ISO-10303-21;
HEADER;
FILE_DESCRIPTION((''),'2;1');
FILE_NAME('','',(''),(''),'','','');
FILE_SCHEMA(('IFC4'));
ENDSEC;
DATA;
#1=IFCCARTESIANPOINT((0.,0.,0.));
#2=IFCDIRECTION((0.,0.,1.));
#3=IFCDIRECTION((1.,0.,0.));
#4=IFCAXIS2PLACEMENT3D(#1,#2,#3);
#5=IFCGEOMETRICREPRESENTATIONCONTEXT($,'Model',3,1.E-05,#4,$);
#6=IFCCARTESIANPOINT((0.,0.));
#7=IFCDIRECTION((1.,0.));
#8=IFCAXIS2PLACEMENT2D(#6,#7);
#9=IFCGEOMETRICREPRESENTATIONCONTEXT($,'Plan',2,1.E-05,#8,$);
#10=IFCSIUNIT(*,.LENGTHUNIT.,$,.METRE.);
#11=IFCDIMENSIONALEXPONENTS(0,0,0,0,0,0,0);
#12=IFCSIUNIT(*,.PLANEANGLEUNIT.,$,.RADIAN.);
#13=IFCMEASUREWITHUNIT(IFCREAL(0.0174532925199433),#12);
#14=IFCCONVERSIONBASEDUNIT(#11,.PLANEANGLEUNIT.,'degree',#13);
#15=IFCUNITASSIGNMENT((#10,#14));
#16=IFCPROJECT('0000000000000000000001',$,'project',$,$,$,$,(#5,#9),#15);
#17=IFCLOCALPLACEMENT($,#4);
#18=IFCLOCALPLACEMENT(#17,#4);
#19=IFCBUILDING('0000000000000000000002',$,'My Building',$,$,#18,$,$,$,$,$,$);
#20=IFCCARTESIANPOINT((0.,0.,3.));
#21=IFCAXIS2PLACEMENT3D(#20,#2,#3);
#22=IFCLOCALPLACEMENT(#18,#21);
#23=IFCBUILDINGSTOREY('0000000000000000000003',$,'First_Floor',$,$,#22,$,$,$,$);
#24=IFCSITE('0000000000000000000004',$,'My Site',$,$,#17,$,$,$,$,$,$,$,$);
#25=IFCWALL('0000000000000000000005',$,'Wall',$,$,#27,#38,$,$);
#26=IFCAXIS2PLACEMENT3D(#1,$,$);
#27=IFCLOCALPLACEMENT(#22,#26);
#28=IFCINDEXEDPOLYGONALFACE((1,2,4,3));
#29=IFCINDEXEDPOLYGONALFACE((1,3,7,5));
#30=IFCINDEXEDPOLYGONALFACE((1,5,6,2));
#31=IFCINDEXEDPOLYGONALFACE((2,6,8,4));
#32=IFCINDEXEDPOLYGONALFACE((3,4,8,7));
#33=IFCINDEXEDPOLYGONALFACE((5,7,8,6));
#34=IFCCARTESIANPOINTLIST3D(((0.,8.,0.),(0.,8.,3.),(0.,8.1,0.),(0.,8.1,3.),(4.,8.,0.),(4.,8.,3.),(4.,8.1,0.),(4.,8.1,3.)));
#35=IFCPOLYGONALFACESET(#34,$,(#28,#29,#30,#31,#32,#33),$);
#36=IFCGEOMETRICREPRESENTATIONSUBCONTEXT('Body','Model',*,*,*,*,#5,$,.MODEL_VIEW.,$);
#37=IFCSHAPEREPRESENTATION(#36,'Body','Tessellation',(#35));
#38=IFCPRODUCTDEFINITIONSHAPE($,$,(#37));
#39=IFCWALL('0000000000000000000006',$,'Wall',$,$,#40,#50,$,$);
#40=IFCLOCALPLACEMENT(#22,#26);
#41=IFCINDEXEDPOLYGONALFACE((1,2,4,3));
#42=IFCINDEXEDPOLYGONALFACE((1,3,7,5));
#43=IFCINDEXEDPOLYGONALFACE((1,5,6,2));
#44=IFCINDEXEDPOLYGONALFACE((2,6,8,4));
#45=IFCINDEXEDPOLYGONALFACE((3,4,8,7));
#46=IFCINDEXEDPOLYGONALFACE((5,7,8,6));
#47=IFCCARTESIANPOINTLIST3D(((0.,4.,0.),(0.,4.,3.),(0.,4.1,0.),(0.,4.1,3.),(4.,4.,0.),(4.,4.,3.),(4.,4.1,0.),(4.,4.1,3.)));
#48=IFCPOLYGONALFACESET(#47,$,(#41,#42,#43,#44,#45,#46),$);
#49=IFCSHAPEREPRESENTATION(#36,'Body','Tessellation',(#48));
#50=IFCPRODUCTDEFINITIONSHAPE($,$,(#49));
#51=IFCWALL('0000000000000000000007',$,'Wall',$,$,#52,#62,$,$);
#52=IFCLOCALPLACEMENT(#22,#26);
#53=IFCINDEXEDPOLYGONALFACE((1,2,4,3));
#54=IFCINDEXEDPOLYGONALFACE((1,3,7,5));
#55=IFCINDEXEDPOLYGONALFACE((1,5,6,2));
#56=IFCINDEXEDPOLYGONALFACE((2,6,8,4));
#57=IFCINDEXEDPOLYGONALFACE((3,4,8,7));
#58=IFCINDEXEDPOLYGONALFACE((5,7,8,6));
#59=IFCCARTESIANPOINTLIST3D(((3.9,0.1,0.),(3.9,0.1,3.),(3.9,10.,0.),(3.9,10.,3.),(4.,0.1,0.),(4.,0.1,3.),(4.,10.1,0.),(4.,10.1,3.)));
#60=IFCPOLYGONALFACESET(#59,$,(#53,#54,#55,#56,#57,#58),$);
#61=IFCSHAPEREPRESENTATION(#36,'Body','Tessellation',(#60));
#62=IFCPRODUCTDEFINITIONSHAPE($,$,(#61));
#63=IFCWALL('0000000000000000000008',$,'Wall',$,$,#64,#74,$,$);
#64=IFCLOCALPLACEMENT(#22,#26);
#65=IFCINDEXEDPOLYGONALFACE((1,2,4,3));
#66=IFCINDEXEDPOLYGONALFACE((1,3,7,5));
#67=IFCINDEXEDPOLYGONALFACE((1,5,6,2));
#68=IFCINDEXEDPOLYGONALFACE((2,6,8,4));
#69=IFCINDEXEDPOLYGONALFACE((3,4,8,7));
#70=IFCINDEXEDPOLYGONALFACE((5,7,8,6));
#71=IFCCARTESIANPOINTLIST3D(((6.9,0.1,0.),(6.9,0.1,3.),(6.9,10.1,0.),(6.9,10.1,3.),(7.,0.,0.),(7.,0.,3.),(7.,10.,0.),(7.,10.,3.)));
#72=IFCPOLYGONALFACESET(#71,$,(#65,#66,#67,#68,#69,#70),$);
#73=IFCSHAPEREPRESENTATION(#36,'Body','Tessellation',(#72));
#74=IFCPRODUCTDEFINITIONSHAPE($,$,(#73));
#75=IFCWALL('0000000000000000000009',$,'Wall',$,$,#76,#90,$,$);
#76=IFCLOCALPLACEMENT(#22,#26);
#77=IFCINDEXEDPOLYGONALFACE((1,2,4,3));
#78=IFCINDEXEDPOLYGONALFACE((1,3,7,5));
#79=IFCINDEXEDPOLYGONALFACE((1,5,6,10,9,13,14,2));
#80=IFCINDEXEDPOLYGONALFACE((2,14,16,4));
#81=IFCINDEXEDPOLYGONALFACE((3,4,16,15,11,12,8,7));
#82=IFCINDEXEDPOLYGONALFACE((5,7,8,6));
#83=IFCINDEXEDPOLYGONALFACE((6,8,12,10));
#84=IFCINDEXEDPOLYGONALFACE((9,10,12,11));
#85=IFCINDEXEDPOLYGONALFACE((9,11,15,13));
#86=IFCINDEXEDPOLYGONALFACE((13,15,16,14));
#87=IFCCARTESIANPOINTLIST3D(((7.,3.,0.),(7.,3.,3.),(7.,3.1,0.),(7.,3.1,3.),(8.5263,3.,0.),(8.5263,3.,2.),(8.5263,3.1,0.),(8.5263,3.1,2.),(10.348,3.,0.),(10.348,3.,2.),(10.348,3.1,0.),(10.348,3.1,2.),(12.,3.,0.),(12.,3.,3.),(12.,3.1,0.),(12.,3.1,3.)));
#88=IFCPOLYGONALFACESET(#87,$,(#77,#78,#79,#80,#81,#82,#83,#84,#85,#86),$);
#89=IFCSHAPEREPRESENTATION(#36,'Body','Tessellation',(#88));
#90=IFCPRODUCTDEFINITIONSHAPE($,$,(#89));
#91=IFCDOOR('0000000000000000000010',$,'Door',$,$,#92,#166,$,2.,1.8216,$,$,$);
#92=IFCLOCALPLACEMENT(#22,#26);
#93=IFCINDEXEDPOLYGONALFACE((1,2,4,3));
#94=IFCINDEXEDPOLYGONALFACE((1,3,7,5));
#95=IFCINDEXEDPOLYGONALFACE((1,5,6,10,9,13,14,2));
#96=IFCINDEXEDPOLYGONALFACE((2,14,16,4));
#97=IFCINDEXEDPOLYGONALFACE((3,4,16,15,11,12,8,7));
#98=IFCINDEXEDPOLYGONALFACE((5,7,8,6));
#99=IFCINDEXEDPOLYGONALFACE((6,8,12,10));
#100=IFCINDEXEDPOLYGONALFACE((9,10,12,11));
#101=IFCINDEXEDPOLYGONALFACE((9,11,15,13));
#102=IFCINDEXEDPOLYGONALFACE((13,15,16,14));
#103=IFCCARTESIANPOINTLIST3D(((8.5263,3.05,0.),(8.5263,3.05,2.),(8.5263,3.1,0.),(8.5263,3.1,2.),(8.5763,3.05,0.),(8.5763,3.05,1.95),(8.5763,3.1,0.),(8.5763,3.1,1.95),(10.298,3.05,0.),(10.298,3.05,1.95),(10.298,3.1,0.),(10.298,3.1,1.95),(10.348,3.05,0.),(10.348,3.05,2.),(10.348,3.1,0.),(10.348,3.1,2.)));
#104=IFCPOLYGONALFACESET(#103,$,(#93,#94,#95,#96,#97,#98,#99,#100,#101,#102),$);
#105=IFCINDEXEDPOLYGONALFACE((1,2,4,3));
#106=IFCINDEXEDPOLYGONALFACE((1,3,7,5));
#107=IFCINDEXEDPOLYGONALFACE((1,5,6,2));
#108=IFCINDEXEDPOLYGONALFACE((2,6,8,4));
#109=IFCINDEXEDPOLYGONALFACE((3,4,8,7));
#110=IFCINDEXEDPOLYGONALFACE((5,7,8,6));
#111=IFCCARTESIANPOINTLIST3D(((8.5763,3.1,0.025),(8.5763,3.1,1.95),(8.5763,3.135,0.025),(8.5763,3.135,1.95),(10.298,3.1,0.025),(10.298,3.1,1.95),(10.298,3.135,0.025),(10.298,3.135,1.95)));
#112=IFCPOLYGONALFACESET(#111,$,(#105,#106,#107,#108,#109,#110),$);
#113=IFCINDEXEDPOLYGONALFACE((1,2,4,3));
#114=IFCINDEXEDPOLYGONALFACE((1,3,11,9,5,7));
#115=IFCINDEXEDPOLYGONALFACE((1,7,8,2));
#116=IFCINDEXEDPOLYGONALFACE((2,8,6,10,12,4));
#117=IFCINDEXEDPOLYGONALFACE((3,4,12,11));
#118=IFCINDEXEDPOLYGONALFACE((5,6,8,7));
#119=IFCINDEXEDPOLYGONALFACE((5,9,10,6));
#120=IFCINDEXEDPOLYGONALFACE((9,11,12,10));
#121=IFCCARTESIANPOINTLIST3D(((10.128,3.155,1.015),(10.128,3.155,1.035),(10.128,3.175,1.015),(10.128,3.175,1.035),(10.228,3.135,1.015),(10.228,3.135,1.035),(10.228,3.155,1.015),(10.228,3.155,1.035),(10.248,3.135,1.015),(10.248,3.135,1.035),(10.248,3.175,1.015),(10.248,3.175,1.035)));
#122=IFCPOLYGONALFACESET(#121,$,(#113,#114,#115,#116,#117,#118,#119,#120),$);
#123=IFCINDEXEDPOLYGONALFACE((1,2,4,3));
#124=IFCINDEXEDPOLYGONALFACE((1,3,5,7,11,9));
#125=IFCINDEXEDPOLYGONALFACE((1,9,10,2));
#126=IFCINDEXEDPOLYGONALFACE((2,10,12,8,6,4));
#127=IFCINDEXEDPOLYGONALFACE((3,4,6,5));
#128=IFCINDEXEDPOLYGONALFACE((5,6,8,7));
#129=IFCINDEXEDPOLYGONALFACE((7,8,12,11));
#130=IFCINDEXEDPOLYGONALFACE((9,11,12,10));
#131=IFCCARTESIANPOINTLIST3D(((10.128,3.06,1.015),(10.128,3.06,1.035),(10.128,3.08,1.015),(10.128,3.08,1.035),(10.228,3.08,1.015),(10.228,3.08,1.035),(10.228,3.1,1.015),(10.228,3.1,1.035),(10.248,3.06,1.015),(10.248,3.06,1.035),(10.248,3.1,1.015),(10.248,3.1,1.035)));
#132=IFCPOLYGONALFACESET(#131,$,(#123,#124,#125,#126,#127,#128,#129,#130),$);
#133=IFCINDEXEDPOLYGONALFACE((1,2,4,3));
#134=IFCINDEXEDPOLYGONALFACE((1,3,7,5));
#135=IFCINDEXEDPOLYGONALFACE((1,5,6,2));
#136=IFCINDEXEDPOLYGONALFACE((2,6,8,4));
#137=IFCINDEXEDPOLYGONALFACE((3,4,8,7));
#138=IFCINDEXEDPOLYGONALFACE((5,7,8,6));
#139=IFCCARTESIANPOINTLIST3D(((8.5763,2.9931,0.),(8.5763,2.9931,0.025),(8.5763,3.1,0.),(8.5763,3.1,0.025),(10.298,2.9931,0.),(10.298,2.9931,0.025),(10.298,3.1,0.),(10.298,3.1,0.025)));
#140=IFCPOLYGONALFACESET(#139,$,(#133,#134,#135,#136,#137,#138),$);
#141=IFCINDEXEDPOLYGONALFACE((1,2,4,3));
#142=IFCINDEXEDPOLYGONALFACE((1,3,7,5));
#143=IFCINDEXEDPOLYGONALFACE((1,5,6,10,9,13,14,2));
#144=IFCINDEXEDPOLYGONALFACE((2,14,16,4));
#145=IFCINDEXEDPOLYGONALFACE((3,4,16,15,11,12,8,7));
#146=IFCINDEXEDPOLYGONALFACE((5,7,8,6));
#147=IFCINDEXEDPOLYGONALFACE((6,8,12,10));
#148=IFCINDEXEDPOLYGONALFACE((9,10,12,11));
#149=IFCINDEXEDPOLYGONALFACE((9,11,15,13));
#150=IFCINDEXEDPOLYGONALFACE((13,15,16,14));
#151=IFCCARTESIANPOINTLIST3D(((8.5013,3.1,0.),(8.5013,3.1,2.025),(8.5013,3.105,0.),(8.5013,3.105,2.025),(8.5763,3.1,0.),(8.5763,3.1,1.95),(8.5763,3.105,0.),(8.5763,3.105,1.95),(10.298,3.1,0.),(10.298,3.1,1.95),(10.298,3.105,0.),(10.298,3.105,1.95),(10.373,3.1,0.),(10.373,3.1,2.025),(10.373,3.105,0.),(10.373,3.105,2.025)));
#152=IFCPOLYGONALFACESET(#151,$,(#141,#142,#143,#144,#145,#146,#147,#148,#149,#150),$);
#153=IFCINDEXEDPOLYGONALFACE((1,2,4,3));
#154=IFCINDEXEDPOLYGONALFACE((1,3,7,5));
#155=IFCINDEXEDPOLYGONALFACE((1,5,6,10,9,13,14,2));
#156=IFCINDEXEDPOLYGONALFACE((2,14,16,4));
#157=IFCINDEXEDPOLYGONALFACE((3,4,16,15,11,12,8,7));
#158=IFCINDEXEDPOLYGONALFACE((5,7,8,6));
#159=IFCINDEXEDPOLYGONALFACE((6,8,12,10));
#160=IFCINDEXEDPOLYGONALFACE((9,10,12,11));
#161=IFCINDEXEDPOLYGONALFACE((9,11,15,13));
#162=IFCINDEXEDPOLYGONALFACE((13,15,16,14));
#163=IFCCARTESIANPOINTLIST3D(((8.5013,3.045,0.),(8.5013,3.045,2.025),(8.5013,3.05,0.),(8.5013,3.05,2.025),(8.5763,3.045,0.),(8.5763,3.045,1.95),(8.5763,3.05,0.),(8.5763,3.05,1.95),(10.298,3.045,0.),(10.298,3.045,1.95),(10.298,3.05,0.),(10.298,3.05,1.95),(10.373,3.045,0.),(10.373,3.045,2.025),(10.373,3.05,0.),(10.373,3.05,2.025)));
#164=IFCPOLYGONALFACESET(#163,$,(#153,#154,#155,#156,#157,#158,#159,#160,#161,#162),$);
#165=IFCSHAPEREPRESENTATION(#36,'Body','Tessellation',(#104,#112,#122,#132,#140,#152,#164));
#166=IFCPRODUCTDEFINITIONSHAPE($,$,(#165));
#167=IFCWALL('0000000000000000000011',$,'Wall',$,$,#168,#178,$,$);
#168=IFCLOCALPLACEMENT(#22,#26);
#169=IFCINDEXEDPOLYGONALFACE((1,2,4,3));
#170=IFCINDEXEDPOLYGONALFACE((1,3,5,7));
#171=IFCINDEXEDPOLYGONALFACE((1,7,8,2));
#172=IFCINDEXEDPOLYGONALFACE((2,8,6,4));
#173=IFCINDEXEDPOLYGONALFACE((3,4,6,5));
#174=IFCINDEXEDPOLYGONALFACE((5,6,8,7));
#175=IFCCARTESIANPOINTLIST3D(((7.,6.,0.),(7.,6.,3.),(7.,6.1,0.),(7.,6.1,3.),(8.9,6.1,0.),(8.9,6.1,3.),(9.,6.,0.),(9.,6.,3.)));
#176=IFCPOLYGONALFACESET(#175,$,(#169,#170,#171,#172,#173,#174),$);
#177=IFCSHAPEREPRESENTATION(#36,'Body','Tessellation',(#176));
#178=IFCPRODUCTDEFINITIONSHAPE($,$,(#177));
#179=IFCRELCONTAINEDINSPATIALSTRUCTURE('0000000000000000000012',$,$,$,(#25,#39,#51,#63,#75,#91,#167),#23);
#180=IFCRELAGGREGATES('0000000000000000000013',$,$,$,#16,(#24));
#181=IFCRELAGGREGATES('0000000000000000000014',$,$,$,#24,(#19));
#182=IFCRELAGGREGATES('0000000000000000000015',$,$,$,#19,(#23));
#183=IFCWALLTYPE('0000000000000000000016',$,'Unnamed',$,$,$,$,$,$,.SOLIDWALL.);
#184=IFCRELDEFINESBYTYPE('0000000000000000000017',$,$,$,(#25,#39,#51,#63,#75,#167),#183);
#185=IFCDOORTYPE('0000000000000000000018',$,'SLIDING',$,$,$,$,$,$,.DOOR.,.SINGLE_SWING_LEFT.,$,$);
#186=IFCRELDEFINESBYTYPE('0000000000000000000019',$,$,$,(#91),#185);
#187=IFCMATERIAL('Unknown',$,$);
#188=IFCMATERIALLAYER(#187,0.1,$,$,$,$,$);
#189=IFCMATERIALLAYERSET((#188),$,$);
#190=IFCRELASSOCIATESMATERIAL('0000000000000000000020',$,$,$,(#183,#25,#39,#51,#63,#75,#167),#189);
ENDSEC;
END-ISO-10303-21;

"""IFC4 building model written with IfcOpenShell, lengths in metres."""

from ifc_helpers import new_model, entity, si_unit, converted_unit, frame, origin_with_axes, origin_2d_with_axis, place, context, subcontext, project, spatial, line, indexed_curve, outline, extrude, shape, source, transform, mapped, material, layer, layer_set, layer_usage, type_object, type_shapes, element, fill, save


model = new_model("IFC4")

# Units and contexts
model_context = context("Model", 3, precision=1e-05, world=origin_with_axes())
plan_context = context("Plan", 2, precision=1e-05, world=origin_2d_with_axis())
body_context_1 = subcontext(model_context, "Body", "Model", "MODEL_VIEW")
body_context_2 = subcontext(plan_context, "Body", "Plan", "PLAN_VIEW")
ifc_project = project(units=[si_unit("LENGTHUNIT", "METRE"), converted_unit("PLANEANGLEUNIT", "degree", entity("IfcReal", 0.0174532925199433), si_unit("PLANEANGLEUNIT", "RADIAN"), dimensions=[0, 0, 0, 0, 0, 0, 0])], contexts=[model_context, plan_context])

# Site, building, storey
site_placement = place(None, origin_with_axes())
site = spatial("IfcSite", under=ifc_project, at=site_placement, Name="My Site")
building_placement = place(site_placement, origin_with_axes())
building = spatial("IfcBuilding", under=site, at=building_placement, Name="My Building")
storey_placement = place(building_placement, frame((0.0, 0.0, 3.0), z_axis=(0.0, 0.0, 1.0), x_axis=(1.0, 0.0, 0.0)))
storey = spatial("IfcBuildingStorey", under=building, at=storey_placement, Name="First_Floor")

# Walls
ifc_material = material(Name="Unknown")
ifc_layer = layer(ifc_material, 0.1)
ifc_layer_set = layer_set([ifc_layer])
ifc_layer_usage_1 = layer_usage(ifc_layer_set, "AXIS2", "POSITIVE", 0.0)
wall_type = type_object("IfcWallType", Name="Unnamed", PredefinedType="SOLIDWALL", material=ifc_layer_set)
wall_1_placement = place(storey_placement, frame((0.0, 8.0, 0.0), z_axis=(0.0, 0.0, 1.0), x_axis=(1.0, 0.0, 0.0)))
element("IfcWall", 1, at=wall_1_placement, inside=storey, type_object=wall_type, material=ifc_layer_usage_1, Name="Wall", context=body_context_1, shape_type="SweptSolid", body=[
    extrude(outline(indexed_curve([(0.0, 0.0), (0.0, 0.1), (4.0, 0.1), (4.0, 0.0)], segments=[line(1, 2, 3, 4, 1)])), origin_with_axes(), (0.0, 0.0, 1.0), 3.0),
])
ifc_layer_usage_2 = layer_usage(ifc_layer_set, "AXIS2", "POSITIVE", 0.0)
wall_2_placement = place(storey_placement, frame((0.0, 4.0, 0.0), z_axis=(0.0, 0.0, 1.0), x_axis=(1.0, 0.0, 0.0)))
element("IfcWall", 2, at=wall_2_placement, inside=storey, type_object=wall_type, material=ifc_layer_usage_2, Name="Wall", context=body_context_1, shape_type="SweptSolid", body=[
    extrude(outline(indexed_curve([(0.0, 0.0), (0.0, 0.1), (4.0, 0.1), (4.0, 0.0)], segments=[line(1, 2, 3, 4, 1)])), origin_with_axes(), (0.0, 0.0, 1.0), 3.0),
])
ifc_layer_usage_3 = layer_usage(ifc_layer_set, "AXIS2", "POSITIVE", 0.0)
wall_3_placement = place(storey_placement, frame((3.9, 10.1, 0.0), z_axis=(0.0, 0.0, 1.0), x_axis=(0.0, -1.0, 0.0)))
element("IfcWall", 3, at=wall_3_placement, inside=storey, type_object=wall_type, material=ifc_layer_usage_3, Name="Wall", context=body_context_1, shape_type="SweptSolid", body=[
    extrude(outline(indexed_curve([(0.1, 0.0), (0.0, 0.1), (10.0, 0.1), (10.0, 0.0)], segments=[line(1, 2, 3, 4, 1)])), origin_with_axes(), (0.0, 0.0, 1.0), 3.0),
])
ifc_layer_usage_4 = layer_usage(ifc_layer_set, "AXIS2", "POSITIVE", 0.0)
wall_4_placement = place(storey_placement, frame((6.9, 10.0, 0.0), z_axis=(0.0, 0.0, 1.0), x_axis=(0.0, -1.0, 0.0)))
element("IfcWall", 4, at=wall_4_placement, inside=storey, type_object=wall_type, material=ifc_layer_usage_4, Name="Wall", context=body_context_1, shape_type="SweptSolid", body=[
    extrude(outline(indexed_curve([(-0.1, 0.0), (0.0, 0.1), (10.0, 0.1), (9.9, 0.0)], segments=[line(1, 2, 3, 4, 1)])), origin_with_axes(), (0.0, 0.0, 1.0), 3.0),
])

# Wall, opening, door
ifc_layer_usage_5 = layer_usage(ifc_layer_set, "AXIS2", "POSITIVE", 0.0)
wall_5_placement = place(storey_placement, frame((7.0, 3.0, 0.0), z_axis=(0.0, 0.0, 1.0), x_axis=(1.0, 0.0, 0.0)))
wall_5 = element("IfcWall", 5, at=wall_5_placement, inside=storey, type_object=wall_type, material=ifc_layer_usage_5, Name="Wall", context=body_context_1, shape_type="SweptSolid", body=[
    extrude(outline(indexed_curve([(0.0, 0.0), (0.0, 0.1), (5.0, 0.1), (5.0, 0.0)], segments=[line(1, 2, 3, 4, 1)])), origin_with_axes(), (0.0, 0.0, 1.0), 3.0),
])
shared_shape_1 = source(origin_with_axes(), body_context_1, "Body", "SweptSolid", [
    extrude(outline(indexed_curve([(0.0, 0.0), (1.8216, 0.0), (1.8216, 2.0), (0.0, 2.0)], segments=[line(1, 2, 3, 4, 1)])), frame((0.0, -0.6, 0.0), z_axis=(0.0, -1.0, 0.0), x_axis=(1.0, 0.0, 0.0)), (0.0, 0.0, -1.0), 1.2),
])
opening_1_placement = place(wall_5_placement, frame((3.348, 0.1, 0.0), z_axis=(0.0, 0.0, 1.0), x_axis=(-1.0, 0.0, 0.0)))
opening_1 = element("IfcOpeningElement", 6, at=opening_1_placement, cuts=wall_5, PredefinedType="OPENING", context=body_context_1, shape_type="MappedRepresentation", body=[
    mapped(shared_shape_1, transform((0.0, 0.0, 0.0), x_axis=(1.0, 0.0, 0.0), y_axis=(0.0, 1.0, 0.0), z_axis=(0.0, 0.0, 1.0), scale=1.0)),
])
door_type_1 = type_object("IfcDoorType", Name="SLIDING", OperationType="SINGLE_SWING_LEFT", PredefinedType="DOOR")
shared_shape_2 = source(origin_with_axes(), body_context_1, "Body", "SweptSolid", [
    extrude(outline(indexed_curve([(0.0, 0.0), (0.0, 2.0), (1.8216, 2.0), (1.8216, 0.0), (1.7716, 0.0), (1.7716, 1.95), (0.05, 1.95), (0.05, 0.0)], segments=[line(1, 2, 3, 4, 5, 6, 7, 8, 1)])), frame((0.0, 0.0, 0.0), z_axis=(0.0, -1.0, 0.0), x_axis=(1.0, 0.0, 0.0)), (0.0, 0.0, -1.0), 0.05),
    extrude(outline(indexed_curve([(0.0, 0.0), (1.7216, 0.0), (1.7216, 0.035), (0.0, 0.035)], segments=[line(1, 2, 3, 4, 1)])), frame((0.05, -0.035, 0.025), z_axis=(0.0, 0.0, 1.0), x_axis=(1.0, 0.0, 0.0)), (0.0, 0.0, 1.0), 1.925),
    extrude(outline(indexed_curve([(0.0, 0.0), (0.0, -0.04), (0.12, -0.04), (0.12, -0.02), (0.02, -0.02), (0.02, 0.0)], segments=[line(1, 2, 3, 4, 5, 6, 1)])), frame((0.1, -0.035, 1.015), z_axis=(0.0, 0.0, 1.0), x_axis=(1.0, 0.0, 0.0)), (0.0, 0.0, 1.0), 0.02),
    extrude(outline(indexed_curve([(0.0, 0.0), (0.0, 0.04), (0.12, 0.04), (0.12, 0.02), (0.02, 0.02), (0.02, 0.0)], segments=[line(1, 2, 3, 4, 5, 6, 1)])), frame((0.1, 0.0, 1.015), z_axis=(0.0, 0.0, 1.0), x_axis=(1.0, 0.0, 0.0)), (0.0, 0.0, 1.0), 0.02),
    extrude(outline(indexed_curve([(0.0, 0.0), (1.7216, 0.0), (1.7216, 0.1069), (0.0, 0.1069)], segments=[line(1, 2, 3, 4, 1)])), frame((0.05, 0.0, 0.0), z_axis=(0.0, 0.0, 1.0), x_axis=(1.0, 0.0, 0.0)), (0.0, 0.0, 1.0), 0.025),
    extrude(outline(indexed_curve([(0.0, 0.0), (0.0, 2.025), (1.8716, 2.025), (1.8716, 0.0), (1.7966, 0.0), (1.7966, 1.95), (0.075, 1.95), (0.075, 0.0)], segments=[line(1, 2, 3, 4, 5, 6, 7, 8, 1)])), frame((-0.025, -0.005, 0.0), z_axis=(0.0, -1.0, 0.0), x_axis=(1.0, 0.0, 0.0)), (0.0, 0.0, -1.0), 0.005),
    extrude(outline(indexed_curve([(0.0, 0.0), (0.0, 2.025), (1.8716, 2.025), (1.8716, 0.0), (1.7966, 0.0), (1.7966, 1.95), (0.075, 1.95), (0.075, 0.0)], segments=[line(1, 2, 3, 4, 5, 6, 7, 8, 1)])), frame((-0.025, 0.05, 0.0), z_axis=(0.0, -1.0, 0.0), x_axis=(1.0, 0.0, 0.0)), (0.0, 0.0, -1.0), 0.005),
])
shared_shape_3 = source(origin_with_axes(), body_context_2, "Body", "Curve2D", [
    entity("IfcIndexedPolyCurve", entity("IfcCartesianPointList2D", [[0.0, 0.0], [0.05, 0.0], [0.05, 0.05], [0.0, 0.05]]), [entity("IfcLineIndex", [1, 2, 3, 4, 1])]),
    entity("IfcIndexedPolyCurve", entity("IfcCartesianPointList2D", [[1.8216, 0.0], [1.7716, 0.0], [1.7716, 0.05], [1.8216, 0.05]]), [entity("IfcLineIndex", [1, 2, 3, 4, 1])]),
    entity("IfcIndexedPolyCurve", entity("IfcCartesianPointList2D", [[2.6325, -0.035], [0.9108, -0.035], [0.9108, 0.0], [2.6325, 0.0]]), [entity("IfcLineIndex", [1, 2, 3, 4, 1])]),
])
type_shapes(door_type_1, [shared_shape_2, shared_shape_3])
door_1_placement = place(opening_1_placement, origin_with_axes())
door_1 = element("IfcDoor", 7, at=door_1_placement, inside=storey, type_object=door_type_1, Name="Door", OverallHeight=2.0, OverallWidth=1.8216, shapes=[
    shape(body_context_1, "Body", "MappedRepresentation", [mapped(shared_shape_2, transform((0.0, 0.0, 0.0), x_axis=(1.0, 0.0, 0.0), y_axis=(0.0, 1.0, 0.0), z_axis=(0.0, 0.0, 1.0), scale=1.0))]),
    shape(body_context_2, "Body", "MappedRepresentation", [mapped(shared_shape_3, transform((0.0, 0.0, 0.0), x_axis=(1.0, 0.0, 0.0), y_axis=(0.0, 1.0, 0.0), z_axis=(0.0, 0.0, 1.0), scale=1.0))]),
])
fill(opening_1, door_1)

# Wall
ifc_layer_usage_6 = layer_usage(ifc_layer_set, "AXIS2", "POSITIVE", 0.0)
wall_6_placement = place(storey_placement, frame((7.0, 6.0, 0.0), z_axis=(0.0, 0.0, 1.0), x_axis=(1.0, 0.0, 0.0)))
element("IfcWall", 8, at=wall_6_placement, inside=storey, type_object=wall_type, material=ifc_layer_usage_6, Name="Wall", context=body_context_1, shape_type="SweptSolid", body=[
    extrude(outline(indexed_curve([(0.0, 0.0), (0.0, 0.1), (1.9, 0.1), (2.0, 0.0)], segments=[line(1, 2, 3, 4, 1)])), origin_with_axes(), (0.0, 0.0, 1.0), 3.0),
])

save(model, "model.ifc")
